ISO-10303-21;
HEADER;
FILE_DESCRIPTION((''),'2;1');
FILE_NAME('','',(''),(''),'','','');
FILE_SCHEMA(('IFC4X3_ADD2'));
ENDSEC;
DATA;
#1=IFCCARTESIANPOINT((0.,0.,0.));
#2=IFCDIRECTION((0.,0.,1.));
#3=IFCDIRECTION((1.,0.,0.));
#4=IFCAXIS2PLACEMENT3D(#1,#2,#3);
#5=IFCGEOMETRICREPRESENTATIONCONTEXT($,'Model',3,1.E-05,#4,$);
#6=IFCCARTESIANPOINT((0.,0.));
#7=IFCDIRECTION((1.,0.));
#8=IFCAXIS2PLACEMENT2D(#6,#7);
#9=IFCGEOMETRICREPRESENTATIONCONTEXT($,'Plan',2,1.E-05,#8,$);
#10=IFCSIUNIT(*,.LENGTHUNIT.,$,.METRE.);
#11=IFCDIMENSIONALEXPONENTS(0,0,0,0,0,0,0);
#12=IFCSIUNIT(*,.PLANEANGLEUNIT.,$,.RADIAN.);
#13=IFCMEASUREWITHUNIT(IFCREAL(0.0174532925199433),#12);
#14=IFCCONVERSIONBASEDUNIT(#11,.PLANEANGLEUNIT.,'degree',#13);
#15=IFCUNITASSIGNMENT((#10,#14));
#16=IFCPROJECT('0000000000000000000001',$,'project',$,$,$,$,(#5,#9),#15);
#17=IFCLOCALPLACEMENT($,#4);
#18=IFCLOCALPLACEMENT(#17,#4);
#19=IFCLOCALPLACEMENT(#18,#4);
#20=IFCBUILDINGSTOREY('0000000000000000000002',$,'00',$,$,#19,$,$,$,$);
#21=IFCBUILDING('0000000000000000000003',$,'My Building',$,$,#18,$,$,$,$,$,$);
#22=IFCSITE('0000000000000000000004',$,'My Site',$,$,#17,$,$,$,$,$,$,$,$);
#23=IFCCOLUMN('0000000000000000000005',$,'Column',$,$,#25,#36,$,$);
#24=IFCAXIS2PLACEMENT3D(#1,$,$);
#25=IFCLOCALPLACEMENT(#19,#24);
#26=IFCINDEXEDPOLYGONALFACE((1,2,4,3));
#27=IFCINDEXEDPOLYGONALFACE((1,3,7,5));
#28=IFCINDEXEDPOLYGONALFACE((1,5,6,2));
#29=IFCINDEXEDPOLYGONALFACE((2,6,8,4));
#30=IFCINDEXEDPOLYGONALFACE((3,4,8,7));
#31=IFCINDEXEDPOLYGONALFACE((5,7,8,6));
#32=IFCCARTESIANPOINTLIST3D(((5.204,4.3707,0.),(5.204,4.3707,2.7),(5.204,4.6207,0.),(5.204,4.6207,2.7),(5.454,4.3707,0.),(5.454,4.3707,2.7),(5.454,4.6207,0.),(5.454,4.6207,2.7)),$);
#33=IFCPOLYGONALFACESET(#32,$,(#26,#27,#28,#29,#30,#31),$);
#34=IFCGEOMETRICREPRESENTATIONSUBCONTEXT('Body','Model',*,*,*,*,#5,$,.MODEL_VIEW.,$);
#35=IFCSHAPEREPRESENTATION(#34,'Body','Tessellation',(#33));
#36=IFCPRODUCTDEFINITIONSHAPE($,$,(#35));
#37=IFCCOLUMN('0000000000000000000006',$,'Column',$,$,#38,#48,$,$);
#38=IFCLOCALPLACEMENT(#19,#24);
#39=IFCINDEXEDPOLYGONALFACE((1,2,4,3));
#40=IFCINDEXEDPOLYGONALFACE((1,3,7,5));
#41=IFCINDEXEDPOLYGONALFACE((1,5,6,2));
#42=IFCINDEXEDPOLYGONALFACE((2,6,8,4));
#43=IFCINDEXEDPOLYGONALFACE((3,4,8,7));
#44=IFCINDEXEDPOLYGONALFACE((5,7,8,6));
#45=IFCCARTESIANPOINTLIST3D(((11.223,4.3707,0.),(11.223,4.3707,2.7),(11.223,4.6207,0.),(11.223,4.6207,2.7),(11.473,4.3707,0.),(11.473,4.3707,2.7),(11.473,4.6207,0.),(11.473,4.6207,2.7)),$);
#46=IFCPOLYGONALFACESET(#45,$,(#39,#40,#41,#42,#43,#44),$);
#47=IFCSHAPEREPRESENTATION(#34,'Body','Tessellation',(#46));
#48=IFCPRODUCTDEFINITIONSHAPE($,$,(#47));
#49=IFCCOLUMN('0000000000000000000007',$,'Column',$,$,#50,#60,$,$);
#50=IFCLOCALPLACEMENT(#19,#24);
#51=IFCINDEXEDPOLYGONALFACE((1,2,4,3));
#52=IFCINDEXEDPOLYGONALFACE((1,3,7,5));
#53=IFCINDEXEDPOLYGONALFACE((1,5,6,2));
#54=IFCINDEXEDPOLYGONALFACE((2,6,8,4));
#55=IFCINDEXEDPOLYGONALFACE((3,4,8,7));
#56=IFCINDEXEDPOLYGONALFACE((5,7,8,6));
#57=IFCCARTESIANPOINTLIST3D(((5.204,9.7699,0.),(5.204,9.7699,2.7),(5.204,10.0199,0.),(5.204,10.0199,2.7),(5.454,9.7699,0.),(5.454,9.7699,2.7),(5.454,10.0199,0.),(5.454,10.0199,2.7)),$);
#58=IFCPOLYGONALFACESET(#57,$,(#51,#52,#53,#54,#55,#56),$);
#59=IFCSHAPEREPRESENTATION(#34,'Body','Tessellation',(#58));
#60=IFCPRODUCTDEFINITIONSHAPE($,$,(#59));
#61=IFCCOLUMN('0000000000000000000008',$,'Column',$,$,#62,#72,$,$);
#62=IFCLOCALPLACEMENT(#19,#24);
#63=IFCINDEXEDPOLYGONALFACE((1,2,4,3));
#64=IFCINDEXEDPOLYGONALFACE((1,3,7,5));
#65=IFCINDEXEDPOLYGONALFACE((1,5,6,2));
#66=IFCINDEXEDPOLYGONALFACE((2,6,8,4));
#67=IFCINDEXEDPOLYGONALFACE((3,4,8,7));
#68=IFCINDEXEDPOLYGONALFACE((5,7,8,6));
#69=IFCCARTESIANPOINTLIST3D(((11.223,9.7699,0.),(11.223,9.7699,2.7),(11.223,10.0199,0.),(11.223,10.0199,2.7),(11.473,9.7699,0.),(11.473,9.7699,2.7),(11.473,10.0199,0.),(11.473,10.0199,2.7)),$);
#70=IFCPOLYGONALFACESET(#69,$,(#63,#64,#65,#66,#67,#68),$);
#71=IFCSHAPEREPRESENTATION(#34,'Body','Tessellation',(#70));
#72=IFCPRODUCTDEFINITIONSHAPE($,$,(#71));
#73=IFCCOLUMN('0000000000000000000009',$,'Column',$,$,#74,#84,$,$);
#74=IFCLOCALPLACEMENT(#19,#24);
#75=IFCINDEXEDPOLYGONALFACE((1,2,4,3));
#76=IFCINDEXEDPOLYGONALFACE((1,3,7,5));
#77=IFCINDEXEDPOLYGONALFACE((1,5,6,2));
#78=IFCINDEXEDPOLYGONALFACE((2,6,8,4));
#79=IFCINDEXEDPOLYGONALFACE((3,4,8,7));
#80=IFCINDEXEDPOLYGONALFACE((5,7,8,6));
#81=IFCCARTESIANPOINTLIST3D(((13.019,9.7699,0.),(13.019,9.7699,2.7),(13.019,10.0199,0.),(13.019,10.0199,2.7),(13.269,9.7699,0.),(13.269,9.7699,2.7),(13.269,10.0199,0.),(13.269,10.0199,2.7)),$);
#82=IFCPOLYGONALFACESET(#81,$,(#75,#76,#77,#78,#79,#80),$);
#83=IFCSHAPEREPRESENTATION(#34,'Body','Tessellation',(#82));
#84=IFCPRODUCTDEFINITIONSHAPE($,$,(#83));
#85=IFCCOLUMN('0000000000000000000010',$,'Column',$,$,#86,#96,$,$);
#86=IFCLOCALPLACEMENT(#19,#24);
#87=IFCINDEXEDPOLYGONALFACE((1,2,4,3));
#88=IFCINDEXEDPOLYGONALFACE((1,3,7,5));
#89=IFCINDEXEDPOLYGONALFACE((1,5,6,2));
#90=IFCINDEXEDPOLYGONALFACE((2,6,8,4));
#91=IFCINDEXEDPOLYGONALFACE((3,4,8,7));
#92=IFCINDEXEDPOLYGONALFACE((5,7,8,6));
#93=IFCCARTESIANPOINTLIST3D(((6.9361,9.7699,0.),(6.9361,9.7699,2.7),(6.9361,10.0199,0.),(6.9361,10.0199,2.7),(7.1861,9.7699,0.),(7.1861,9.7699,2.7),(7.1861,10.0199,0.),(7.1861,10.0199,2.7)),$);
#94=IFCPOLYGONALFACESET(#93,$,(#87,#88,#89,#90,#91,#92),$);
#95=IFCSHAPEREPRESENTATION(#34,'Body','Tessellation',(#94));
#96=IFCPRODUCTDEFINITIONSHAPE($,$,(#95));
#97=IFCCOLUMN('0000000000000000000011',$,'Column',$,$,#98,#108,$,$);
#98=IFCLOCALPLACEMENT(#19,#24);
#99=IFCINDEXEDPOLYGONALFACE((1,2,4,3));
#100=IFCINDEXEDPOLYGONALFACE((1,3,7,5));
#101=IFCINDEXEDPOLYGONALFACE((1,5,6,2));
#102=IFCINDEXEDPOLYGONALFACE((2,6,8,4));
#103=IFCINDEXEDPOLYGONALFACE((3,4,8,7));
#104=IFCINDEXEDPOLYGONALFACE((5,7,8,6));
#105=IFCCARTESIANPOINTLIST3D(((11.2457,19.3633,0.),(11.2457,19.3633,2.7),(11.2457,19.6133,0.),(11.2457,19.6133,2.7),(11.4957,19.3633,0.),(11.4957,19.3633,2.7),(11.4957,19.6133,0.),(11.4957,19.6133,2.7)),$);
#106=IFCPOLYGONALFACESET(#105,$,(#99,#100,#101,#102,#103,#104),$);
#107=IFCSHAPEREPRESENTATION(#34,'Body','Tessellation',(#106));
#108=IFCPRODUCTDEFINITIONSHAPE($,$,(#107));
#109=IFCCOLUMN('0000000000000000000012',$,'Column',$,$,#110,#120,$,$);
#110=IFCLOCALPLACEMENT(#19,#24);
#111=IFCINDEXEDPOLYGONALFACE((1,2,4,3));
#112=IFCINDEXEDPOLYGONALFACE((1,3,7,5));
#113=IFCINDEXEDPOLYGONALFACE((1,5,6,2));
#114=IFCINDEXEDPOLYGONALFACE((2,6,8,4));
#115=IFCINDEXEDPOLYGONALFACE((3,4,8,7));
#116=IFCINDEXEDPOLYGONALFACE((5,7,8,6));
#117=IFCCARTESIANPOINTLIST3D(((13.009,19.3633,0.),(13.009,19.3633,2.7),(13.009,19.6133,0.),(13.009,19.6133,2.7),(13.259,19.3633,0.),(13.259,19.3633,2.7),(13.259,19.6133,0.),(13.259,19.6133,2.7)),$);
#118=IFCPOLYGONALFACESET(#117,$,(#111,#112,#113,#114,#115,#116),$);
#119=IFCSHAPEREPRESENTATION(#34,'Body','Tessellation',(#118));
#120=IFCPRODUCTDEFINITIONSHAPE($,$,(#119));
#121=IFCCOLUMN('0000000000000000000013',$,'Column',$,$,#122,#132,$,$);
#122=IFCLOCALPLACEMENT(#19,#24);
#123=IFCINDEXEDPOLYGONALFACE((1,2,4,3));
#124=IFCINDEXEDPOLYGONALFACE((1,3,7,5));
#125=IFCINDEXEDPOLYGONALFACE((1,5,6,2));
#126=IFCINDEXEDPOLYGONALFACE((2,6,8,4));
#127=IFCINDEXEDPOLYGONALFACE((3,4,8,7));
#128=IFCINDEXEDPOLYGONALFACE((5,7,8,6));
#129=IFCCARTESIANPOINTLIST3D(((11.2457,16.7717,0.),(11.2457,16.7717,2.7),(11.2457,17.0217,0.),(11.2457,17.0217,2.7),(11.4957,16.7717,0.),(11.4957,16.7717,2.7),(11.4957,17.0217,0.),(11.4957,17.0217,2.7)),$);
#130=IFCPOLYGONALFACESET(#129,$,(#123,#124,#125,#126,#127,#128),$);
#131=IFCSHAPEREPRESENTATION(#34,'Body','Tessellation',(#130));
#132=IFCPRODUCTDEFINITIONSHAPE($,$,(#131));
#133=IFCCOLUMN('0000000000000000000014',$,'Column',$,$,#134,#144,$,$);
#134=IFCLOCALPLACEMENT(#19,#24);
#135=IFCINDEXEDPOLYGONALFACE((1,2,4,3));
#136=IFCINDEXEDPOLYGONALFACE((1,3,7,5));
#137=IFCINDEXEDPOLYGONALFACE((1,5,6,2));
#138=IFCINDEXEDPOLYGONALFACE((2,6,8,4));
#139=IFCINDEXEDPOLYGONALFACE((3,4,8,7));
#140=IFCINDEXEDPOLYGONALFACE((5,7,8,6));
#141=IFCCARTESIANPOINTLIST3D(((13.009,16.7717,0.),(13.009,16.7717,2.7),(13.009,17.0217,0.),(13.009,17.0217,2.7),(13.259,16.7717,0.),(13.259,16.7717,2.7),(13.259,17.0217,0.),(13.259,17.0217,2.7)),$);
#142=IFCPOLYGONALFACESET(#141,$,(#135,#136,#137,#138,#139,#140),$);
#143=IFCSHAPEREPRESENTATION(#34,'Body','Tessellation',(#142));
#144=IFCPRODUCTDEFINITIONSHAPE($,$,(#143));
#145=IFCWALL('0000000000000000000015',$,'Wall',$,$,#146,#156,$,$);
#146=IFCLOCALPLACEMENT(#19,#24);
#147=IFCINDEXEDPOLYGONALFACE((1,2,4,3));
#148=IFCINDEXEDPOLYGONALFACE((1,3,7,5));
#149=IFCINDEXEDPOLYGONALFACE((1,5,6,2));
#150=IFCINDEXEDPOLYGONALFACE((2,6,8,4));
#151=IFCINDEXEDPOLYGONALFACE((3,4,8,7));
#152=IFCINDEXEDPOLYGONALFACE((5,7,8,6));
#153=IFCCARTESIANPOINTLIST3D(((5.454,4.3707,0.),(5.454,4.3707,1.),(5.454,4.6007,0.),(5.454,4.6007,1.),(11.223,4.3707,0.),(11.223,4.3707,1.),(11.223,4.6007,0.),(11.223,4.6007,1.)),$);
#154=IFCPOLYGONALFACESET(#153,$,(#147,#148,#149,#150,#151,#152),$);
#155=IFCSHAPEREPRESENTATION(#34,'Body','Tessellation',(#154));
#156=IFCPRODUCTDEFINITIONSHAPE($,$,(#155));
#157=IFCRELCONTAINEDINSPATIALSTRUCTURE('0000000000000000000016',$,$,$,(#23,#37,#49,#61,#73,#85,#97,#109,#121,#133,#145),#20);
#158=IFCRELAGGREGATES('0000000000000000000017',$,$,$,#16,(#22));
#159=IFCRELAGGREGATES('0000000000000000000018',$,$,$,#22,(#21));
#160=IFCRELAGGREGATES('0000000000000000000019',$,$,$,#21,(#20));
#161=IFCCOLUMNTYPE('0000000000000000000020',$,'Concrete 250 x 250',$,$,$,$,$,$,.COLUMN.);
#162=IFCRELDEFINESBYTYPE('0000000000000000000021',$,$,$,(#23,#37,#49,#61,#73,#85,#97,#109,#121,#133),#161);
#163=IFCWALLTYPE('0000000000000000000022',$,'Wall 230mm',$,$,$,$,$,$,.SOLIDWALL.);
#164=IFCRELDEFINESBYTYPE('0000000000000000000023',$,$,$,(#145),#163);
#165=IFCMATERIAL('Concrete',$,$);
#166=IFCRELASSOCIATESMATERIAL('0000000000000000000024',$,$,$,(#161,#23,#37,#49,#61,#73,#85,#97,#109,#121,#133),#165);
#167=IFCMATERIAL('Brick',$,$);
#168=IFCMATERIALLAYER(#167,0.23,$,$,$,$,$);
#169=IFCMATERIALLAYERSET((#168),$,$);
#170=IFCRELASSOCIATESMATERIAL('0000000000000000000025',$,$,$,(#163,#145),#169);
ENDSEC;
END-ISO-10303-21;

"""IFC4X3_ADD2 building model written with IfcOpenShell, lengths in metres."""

from ifc_helpers import new_model, entity, si_unit, converted_unit, frame, origin_with_axes, origin_2d_with_axis, place, context, subcontext, project, spatial, indexed_curve, rectangle, outline, extrude, material, layer, layer_set, layer_usage, material_profile, profile_set, profile_usage, type_object, element, save


model = new_model("IFC4X3_ADD2")

# Units and contexts
model_context = context("Model", 3, precision=1e-05, world=origin_with_axes())
plan_context = context("Plan", 2, precision=1e-05, world=origin_2d_with_axis())
body_context = subcontext(model_context, "Body", "Model", "MODEL_VIEW")
ifc_project = project(units=[si_unit("LENGTHUNIT", "METRE"), converted_unit("PLANEANGLEUNIT", "degree", entity("IfcReal", 0.0174532925199433), si_unit("PLANEANGLEUNIT", "RADIAN"), dimensions=[0, 0, 0, 0, 0, 0, 0])], contexts=[model_context, plan_context])

# Site, building, storey
site_placement = place(None, origin_with_axes())
site = spatial("IfcSite", under=ifc_project, at=site_placement, Name="My Site")
building_placement = place(site_placement, origin_with_axes())
building = spatial("IfcBuilding", under=site, at=building_placement, Name="My Building")
storey_placement = place(building_placement, origin_with_axes())
storey = spatial("IfcBuildingStorey", under=building, at=storey_placement, Name="00")

# Columns
ifc_material_1 = material(Name="Concrete")
ifc_material_profile = material_profile(ifc_material_1, rectangle(XDim=0.25, YDim=0.25))
ifc_profile_set = profile_set([ifc_material_profile])
ifc_profile_usage_1 = profile_usage(ifc_profile_set, cardinal=5)
column_type = type_object("IfcColumnType", Name="Concrete 250 x 250", PredefinedType="COLUMN", material=ifc_profile_set)
column_1_placement = place(storey_placement, frame((5.329, 4.4957, 0.0), z_axis=(0.0, 0.0, 1.0), x_axis=(1.0, 0.0, 0.0)))
element("IfcColumn", 1, at=column_1_placement, inside=storey, type_object=column_type, material=ifc_profile_usage_1, Name="Column", context=body_context, shape_type="SweptSolid", body=[
    extrude(rectangle(XDim=0.25, YDim=0.25), origin_with_axes(), (0.0, 0.0, 1.0), 2.7),
])
ifc_profile_usage_2 = profile_usage(ifc_profile_set, cardinal=5)
column_2_placement = place(storey_placement, frame((11.348, 4.4957, 0.0), z_axis=(0.0, 0.0, 1.0), x_axis=(1.0, 0.0, 0.0)))
element("IfcColumn", 2, at=column_2_placement, inside=storey, type_object=column_type, material=ifc_profile_usage_2, Name="Column", context=body_context, shape_type="SweptSolid", body=[
    extrude(rectangle(XDim=0.25, YDim=0.25), origin_with_axes(), (0.0, 0.0, 1.0), 2.7),
])
ifc_profile_usage_3 = profile_usage(ifc_profile_set, cardinal=5)
column_3_placement = place(storey_placement, frame((5.329, 9.8949, 0.0), z_axis=(0.0, 0.0, 1.0), x_axis=(1.0, 0.0, 0.0)))
element("IfcColumn", 3, at=column_3_placement, inside=storey, type_object=column_type, material=ifc_profile_usage_3, Name="Column", context=body_context, shape_type="SweptSolid", body=[
    extrude(rectangle(XDim=0.25, YDim=0.25), origin_with_axes(), (0.0, 0.0, 1.0), 2.7),
])
ifc_profile_usage_4 = profile_usage(ifc_profile_set, cardinal=5)
column_4_placement = place(storey_placement, frame((11.348, 9.8949, 0.0), z_axis=(0.0, 0.0, 1.0), x_axis=(1.0, 0.0, 0.0)))
element("IfcColumn", 4, at=column_4_placement, inside=storey, type_object=column_type, material=ifc_profile_usage_4, Name="Column", context=body_context, shape_type="SweptSolid", body=[
    extrude(rectangle(XDim=0.25, YDim=0.25), origin_with_axes(), (0.0, 0.0, 1.0), 2.7),
])
ifc_profile_usage_5 = profile_usage(ifc_profile_set, cardinal=5)
column_5_placement = place(storey_placement, frame((13.144, 9.8949, 0.0), z_axis=(0.0, 0.0, 1.0), x_axis=(1.0, 0.0, 0.0)))
element("IfcColumn", 5, at=column_5_placement, inside=storey, type_object=column_type, material=ifc_profile_usage_5, Name="Column", context=body_context, shape_type="SweptSolid", body=[
    extrude(rectangle(XDim=0.25, YDim=0.25), origin_with_axes(), (0.0, 0.0, 1.0), 2.7),
])
ifc_profile_usage_6 = profile_usage(ifc_profile_set, cardinal=5)
column_6_placement = place(storey_placement, frame((7.0611, 9.8949, 0.0), z_axis=(0.0, 0.0, 1.0), x_axis=(1.0, 0.0, 0.0)))
element("IfcColumn", 6, at=column_6_placement, inside=storey, type_object=column_type, material=ifc_profile_usage_6, Name="Column", context=body_context, shape_type="SweptSolid", body=[
    extrude(rectangle(XDim=0.25, YDim=0.25), origin_with_axes(), (0.0, 0.0, 1.0), 2.7),
])
ifc_profile_usage_7 = profile_usage(ifc_profile_set, cardinal=5)
column_7_placement = place(storey_placement, frame((11.3707, 19.4883, 0.0), z_axis=(0.0, 0.0, 1.0), x_axis=(1.0, 0.0, 0.0)))
element("IfcColumn", 7, at=column_7_placement, inside=storey, type_object=column_type, material=ifc_profile_usage_7, Name="Column", context=body_context, shape_type="SweptSolid", body=[
    extrude(rectangle(XDim=0.25, YDim=0.25), origin_with_axes(), (0.0, 0.0, 1.0), 2.7),
])
ifc_profile_usage_8 = profile_usage(ifc_profile_set, cardinal=5)
column_8_placement = place(storey_placement, frame((13.134, 19.4883, 0.0), z_axis=(0.0, 0.0, 1.0), x_axis=(1.0, 0.0, 0.0)))
element("IfcColumn", 8, at=column_8_placement, inside=storey, type_object=column_type, material=ifc_profile_usage_8, Name="Column", context=body_context, shape_type="SweptSolid", body=[
    extrude(rectangle(XDim=0.25, YDim=0.25), origin_with_axes(), (0.0, 0.0, 1.0), 2.7),
])
ifc_profile_usage_9 = profile_usage(ifc_profile_set, cardinal=5)
column_9_placement = place(storey_placement, frame((11.3707, 16.8967, 0.0), z_axis=(0.0, 0.0, 1.0), x_axis=(1.0, 0.0, 0.0)))
element("IfcColumn", 9, at=column_9_placement, inside=storey, type_object=column_type, material=ifc_profile_usage_9, Name="Column", context=body_context, shape_type="SweptSolid", body=[
    extrude(rectangle(XDim=0.25, YDim=0.25), origin_with_axes(), (0.0, 0.0, 1.0), 2.7),
])
ifc_profile_usage_10 = profile_usage(ifc_profile_set, cardinal=5)
column_10_placement = place(storey_placement, frame((13.134, 16.8967, 0.0), z_axis=(0.0, 0.0, 1.0), x_axis=(1.0, 0.0, 0.0)))
element("IfcColumn", 10, at=column_10_placement, inside=storey, type_object=column_type, material=ifc_profile_usage_10, Name="Column", context=body_context, shape_type="SweptSolid", body=[
    extrude(rectangle(XDim=0.25, YDim=0.25), origin_with_axes(), (0.0, 0.0, 1.0), 2.7),
])

# Wall
ifc_material_2 = material(Name="Brick")
ifc_layer = layer(ifc_material_2, 0.23)
ifc_layer_set = layer_set([ifc_layer])
ifc_layer_usage = layer_usage(ifc_layer_set, "AXIS2", "POSITIVE", 0.0)
wall_type = type_object("IfcWallType", Name="Wall 230mm", PredefinedType="SOLIDWALL", material=ifc_layer_set)
wall_placement = place(storey_placement, frame((5.454, 4.3707, 0.0), z_axis=(0.0, 0.0, 1.0), x_axis=(1.0, 0.0, 0.0)))
element("IfcWall", 11, at=wall_placement, inside=storey, type_object=wall_type, material=ifc_layer_usage, Name="Wall", context=body_context, shape_type="SweptSolid", body=[
    extrude(outline(indexed_curve([(0.0, 0.0), (0.0, 0.23), (5.769, 0.23), (5.769, 0.0), (0.0, 0.0)], self_intersect=False)), origin_with_axes(), (0.0, 0.0, 1.0), 1.0),
])

save(model, "model.ifc")
